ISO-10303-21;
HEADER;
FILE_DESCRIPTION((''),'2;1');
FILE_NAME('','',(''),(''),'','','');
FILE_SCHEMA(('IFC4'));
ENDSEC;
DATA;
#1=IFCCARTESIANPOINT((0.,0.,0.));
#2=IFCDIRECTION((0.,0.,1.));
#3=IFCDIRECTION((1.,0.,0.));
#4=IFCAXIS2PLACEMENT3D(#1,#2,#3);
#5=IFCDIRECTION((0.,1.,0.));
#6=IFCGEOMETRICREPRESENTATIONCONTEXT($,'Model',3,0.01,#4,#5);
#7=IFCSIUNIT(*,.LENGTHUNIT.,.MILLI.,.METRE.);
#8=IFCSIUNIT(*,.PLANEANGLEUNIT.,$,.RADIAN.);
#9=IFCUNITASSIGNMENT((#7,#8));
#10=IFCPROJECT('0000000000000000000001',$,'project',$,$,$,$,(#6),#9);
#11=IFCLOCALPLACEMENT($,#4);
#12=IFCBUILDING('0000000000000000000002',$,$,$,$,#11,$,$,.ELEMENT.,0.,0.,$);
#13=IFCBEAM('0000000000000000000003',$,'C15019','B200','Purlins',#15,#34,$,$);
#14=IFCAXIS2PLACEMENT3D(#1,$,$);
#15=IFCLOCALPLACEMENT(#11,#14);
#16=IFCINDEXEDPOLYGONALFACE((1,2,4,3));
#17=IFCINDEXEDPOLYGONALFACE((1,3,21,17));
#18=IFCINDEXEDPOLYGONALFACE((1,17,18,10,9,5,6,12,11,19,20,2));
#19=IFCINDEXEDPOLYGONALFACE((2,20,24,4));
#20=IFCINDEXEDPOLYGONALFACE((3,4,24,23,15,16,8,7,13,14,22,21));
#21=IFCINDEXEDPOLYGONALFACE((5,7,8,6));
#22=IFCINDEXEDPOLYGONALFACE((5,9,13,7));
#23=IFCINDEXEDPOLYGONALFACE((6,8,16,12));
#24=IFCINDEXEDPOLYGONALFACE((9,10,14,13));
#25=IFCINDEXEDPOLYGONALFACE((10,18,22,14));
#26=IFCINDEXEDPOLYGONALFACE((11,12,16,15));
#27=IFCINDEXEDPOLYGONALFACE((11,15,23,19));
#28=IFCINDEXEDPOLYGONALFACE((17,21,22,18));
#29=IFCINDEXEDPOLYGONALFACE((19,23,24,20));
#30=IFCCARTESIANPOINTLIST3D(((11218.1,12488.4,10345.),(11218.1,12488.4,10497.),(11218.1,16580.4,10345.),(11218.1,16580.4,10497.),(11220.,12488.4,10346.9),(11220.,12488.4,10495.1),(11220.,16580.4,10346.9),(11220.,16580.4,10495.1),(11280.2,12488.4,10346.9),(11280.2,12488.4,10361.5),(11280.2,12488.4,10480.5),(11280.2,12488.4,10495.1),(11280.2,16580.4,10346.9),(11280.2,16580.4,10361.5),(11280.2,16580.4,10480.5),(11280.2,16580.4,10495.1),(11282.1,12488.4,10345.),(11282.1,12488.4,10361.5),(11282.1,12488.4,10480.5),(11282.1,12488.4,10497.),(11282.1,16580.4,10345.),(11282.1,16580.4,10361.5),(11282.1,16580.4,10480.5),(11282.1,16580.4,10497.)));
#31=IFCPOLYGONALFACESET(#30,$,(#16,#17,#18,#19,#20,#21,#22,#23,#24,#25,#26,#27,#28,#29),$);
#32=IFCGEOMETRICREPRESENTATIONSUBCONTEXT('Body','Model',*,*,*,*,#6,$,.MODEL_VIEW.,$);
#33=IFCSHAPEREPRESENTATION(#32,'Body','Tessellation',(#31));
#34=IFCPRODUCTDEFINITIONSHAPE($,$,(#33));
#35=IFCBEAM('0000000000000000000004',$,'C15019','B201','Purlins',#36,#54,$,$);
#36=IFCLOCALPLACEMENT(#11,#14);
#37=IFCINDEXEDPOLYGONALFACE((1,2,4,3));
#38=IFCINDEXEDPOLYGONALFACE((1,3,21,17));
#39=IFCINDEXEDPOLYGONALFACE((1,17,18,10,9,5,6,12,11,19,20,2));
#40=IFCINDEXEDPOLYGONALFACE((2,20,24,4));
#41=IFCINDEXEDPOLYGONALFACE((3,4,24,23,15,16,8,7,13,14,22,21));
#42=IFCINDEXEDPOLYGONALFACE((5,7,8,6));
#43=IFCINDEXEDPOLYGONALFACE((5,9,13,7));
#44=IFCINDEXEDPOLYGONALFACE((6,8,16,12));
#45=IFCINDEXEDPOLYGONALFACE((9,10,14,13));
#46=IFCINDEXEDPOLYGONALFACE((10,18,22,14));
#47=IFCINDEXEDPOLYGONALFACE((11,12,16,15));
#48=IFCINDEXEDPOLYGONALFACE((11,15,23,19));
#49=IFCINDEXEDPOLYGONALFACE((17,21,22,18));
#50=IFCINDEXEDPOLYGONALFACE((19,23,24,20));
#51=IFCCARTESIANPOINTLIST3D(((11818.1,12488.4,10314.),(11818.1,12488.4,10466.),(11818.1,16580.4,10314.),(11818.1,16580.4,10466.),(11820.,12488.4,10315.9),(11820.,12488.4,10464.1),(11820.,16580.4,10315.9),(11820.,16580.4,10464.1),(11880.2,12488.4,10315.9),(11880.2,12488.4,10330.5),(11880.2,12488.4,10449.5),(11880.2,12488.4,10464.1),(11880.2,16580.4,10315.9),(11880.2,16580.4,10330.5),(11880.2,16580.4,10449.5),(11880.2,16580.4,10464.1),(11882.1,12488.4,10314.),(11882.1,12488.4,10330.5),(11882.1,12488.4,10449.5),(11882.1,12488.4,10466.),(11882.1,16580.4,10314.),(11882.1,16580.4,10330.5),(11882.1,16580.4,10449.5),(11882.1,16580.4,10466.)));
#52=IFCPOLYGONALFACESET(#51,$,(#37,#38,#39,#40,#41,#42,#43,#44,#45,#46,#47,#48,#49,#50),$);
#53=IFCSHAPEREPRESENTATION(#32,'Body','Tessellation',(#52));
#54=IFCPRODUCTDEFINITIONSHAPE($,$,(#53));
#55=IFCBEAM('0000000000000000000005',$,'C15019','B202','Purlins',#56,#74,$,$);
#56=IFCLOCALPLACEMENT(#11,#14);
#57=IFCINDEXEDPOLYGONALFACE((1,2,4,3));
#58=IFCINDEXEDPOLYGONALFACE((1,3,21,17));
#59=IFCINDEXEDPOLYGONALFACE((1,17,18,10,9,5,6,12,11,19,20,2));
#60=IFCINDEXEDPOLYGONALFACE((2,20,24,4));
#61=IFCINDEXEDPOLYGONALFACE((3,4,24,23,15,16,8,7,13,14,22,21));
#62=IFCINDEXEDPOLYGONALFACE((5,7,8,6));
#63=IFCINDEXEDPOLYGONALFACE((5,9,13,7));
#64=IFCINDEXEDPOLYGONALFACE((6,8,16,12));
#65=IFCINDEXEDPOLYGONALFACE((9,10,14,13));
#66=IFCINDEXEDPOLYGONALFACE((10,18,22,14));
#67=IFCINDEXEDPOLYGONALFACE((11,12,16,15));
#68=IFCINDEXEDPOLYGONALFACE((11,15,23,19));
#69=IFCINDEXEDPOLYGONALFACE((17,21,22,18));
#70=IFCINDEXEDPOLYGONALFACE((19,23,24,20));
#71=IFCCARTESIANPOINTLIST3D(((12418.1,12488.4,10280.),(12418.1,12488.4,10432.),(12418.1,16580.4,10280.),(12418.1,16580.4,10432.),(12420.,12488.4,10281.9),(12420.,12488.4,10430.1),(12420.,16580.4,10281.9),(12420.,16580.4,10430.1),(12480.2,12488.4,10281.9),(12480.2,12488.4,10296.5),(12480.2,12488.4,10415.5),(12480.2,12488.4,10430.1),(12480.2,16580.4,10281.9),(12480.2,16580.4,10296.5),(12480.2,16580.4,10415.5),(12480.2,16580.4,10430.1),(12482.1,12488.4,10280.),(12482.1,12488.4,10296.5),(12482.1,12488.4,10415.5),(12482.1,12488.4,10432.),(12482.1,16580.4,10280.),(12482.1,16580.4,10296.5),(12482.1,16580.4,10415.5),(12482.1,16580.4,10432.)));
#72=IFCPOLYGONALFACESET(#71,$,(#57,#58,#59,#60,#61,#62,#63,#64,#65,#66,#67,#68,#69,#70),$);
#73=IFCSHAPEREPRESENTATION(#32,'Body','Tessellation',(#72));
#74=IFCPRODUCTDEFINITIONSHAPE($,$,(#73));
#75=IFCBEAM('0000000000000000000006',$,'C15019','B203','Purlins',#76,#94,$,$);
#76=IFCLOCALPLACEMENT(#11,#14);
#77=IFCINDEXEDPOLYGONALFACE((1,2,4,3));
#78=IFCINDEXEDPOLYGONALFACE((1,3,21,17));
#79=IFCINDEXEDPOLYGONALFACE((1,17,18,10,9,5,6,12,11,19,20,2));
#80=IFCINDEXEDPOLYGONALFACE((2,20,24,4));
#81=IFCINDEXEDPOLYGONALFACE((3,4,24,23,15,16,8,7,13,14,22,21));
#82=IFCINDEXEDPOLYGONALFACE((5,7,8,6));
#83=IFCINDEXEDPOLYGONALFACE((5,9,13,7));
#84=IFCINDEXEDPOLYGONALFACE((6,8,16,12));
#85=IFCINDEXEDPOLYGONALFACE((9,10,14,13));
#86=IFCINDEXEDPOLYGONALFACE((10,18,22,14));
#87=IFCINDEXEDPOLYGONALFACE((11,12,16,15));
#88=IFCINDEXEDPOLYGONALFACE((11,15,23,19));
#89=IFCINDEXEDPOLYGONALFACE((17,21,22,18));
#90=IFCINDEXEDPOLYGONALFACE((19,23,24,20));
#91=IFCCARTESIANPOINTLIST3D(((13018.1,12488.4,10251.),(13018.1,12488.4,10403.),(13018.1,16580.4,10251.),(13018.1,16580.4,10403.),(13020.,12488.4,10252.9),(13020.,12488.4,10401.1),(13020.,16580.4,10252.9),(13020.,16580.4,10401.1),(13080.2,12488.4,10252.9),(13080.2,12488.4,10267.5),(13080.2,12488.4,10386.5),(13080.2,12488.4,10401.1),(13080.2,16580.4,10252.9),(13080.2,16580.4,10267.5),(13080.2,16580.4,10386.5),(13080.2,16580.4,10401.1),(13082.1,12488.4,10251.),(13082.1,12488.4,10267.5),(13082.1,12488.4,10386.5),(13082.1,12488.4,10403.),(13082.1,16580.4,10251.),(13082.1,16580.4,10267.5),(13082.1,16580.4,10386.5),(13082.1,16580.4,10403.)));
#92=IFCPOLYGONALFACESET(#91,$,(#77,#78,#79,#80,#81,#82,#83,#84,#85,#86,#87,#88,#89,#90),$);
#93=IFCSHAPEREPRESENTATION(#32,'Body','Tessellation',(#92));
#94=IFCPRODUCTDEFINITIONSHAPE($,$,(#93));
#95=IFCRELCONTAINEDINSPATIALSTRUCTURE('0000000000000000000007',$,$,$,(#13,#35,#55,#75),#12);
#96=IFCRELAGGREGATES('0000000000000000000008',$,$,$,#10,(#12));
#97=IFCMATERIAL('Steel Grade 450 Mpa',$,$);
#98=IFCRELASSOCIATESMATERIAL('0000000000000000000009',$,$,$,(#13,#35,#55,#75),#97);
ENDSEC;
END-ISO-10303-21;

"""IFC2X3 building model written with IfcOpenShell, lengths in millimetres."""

from ifc_helpers import new_model, si_unit, direction, frame, origin, origin_with_axes, origin_2d_with_axis, place, context, subcontext, project, spatial, c_section, extrude, source, transform, mapped, material, element, save


model = new_model("IFC2X3")

# Units and contexts
model_context = context("Model", 3, precision=0.01, world=origin_with_axes(), true_north=direction((0.0, 1.0, 0.0)))
body_context = subcontext(model_context, "Body", "Model", "MODEL_VIEW")
ifc_project = project(units=[si_unit("LENGTHUNIT", "METRE", prefix="MILLI"), si_unit("PLANEANGLEUNIT", "RADIAN")], contexts=[model_context])

# Building
building_placement = place(None, origin_with_axes())
building = spatial("IfcBuilding", under=ifc_project, at=building_placement, CompositionType="ELEMENT", ElevationOfRefHeight=0.0, ElevationOfTerrain=0.0)

# Beams
ifc_material_1 = material(Name="Steel Grade 450 Mpa")
shared_shape_1 = source(origin(), body_context, "Body", "SweptSolid", [
    extrude(c_section(Depth=152.0, Width=64.0, WallThickness=1.9, Girth=16.5, at=origin_2d_with_axis()), origin_with_axes(), (0.0, 0.0, 1.0), 4092.0),
])
beam_1_placement = place(None, frame((11250.1, 16580.4, 10421.0), z_axis=(0.0, -1.0, 0.0), x_axis=(1.0, 0.0, 0.0)))
element("IfcBeam", 1, at=beam_1_placement, inside=building, material=ifc_material_1, Name="C15019", Description="B200", ObjectType="Purlins", context=body_context, shape_type="MappedRepresentation", body=[
    mapped(shared_shape_1, transform((0.0, 0.0, 0.0), scale=1.0)),
])
shared_shape_2 = source(origin(), body_context, "Body", "SweptSolid", [
    extrude(c_section(Depth=152.0, Width=64.0, WallThickness=1.9, Girth=16.5, at=origin_2d_with_axis()), origin_with_axes(), (0.0, 0.0, 1.0), 4092.0),
])
beam_2_placement = place(None, frame((11850.1, 16580.4, 10390.0), z_axis=(0.0, -1.0, 0.0), x_axis=(1.0, 0.0, 0.0)))
element("IfcBeam", 2, at=beam_2_placement, inside=building, material=ifc_material_1, Name="C15019", Description="B201", ObjectType="Purlins", context=body_context, shape_type="MappedRepresentation", body=[
    mapped(shared_shape_2, transform((0.0, 0.0, 0.0), scale=1.0)),
])
shared_shape_3 = source(origin(), body_context, "Body", "SweptSolid", [
    extrude(c_section(Depth=152.0, Width=64.0, WallThickness=1.9, Girth=16.5, at=origin_2d_with_axis()), origin_with_axes(), (0.0, 0.0, 1.0), 4092.0),
])
beam_3_placement = place(None, frame((12450.1, 16580.4, 10356.0), z_axis=(0.0, -1.0, 0.0), x_axis=(1.0, 0.0, 0.0)))
element("IfcBeam", 3, at=beam_3_placement, inside=building, material=ifc_material_1, Name="C15019", Description="B202", ObjectType="Purlins", context=body_context, shape_type="MappedRepresentation", body=[
    mapped(shared_shape_3, transform((0.0, 0.0, 0.0), scale=1.0)),
])
shared_shape_4 = source(origin(), body_context, "Body", "SweptSolid", [
    extrude(c_section(Depth=152.0, Width=64.0, WallThickness=1.9, Girth=16.5, at=origin_2d_with_axis()), origin_with_axes(), (0.0, 0.0, 1.0), 4092.0),
])
beam_4_placement = place(None, frame((13050.1, 16580.4, 10327.0), z_axis=(0.0, -1.0, 0.0), x_axis=(1.0, 0.0, 0.0)))
element("IfcBeam", 4, at=beam_4_placement, inside=building, material=ifc_material_1, Name="C15019", Description="B203", ObjectType="Purlins", context=body_context, shape_type="MappedRepresentation", body=[
    mapped(shared_shape_4, transform((0.0, 0.0, 0.0), scale=1.0)),
])

save(model, "model.ifc")
